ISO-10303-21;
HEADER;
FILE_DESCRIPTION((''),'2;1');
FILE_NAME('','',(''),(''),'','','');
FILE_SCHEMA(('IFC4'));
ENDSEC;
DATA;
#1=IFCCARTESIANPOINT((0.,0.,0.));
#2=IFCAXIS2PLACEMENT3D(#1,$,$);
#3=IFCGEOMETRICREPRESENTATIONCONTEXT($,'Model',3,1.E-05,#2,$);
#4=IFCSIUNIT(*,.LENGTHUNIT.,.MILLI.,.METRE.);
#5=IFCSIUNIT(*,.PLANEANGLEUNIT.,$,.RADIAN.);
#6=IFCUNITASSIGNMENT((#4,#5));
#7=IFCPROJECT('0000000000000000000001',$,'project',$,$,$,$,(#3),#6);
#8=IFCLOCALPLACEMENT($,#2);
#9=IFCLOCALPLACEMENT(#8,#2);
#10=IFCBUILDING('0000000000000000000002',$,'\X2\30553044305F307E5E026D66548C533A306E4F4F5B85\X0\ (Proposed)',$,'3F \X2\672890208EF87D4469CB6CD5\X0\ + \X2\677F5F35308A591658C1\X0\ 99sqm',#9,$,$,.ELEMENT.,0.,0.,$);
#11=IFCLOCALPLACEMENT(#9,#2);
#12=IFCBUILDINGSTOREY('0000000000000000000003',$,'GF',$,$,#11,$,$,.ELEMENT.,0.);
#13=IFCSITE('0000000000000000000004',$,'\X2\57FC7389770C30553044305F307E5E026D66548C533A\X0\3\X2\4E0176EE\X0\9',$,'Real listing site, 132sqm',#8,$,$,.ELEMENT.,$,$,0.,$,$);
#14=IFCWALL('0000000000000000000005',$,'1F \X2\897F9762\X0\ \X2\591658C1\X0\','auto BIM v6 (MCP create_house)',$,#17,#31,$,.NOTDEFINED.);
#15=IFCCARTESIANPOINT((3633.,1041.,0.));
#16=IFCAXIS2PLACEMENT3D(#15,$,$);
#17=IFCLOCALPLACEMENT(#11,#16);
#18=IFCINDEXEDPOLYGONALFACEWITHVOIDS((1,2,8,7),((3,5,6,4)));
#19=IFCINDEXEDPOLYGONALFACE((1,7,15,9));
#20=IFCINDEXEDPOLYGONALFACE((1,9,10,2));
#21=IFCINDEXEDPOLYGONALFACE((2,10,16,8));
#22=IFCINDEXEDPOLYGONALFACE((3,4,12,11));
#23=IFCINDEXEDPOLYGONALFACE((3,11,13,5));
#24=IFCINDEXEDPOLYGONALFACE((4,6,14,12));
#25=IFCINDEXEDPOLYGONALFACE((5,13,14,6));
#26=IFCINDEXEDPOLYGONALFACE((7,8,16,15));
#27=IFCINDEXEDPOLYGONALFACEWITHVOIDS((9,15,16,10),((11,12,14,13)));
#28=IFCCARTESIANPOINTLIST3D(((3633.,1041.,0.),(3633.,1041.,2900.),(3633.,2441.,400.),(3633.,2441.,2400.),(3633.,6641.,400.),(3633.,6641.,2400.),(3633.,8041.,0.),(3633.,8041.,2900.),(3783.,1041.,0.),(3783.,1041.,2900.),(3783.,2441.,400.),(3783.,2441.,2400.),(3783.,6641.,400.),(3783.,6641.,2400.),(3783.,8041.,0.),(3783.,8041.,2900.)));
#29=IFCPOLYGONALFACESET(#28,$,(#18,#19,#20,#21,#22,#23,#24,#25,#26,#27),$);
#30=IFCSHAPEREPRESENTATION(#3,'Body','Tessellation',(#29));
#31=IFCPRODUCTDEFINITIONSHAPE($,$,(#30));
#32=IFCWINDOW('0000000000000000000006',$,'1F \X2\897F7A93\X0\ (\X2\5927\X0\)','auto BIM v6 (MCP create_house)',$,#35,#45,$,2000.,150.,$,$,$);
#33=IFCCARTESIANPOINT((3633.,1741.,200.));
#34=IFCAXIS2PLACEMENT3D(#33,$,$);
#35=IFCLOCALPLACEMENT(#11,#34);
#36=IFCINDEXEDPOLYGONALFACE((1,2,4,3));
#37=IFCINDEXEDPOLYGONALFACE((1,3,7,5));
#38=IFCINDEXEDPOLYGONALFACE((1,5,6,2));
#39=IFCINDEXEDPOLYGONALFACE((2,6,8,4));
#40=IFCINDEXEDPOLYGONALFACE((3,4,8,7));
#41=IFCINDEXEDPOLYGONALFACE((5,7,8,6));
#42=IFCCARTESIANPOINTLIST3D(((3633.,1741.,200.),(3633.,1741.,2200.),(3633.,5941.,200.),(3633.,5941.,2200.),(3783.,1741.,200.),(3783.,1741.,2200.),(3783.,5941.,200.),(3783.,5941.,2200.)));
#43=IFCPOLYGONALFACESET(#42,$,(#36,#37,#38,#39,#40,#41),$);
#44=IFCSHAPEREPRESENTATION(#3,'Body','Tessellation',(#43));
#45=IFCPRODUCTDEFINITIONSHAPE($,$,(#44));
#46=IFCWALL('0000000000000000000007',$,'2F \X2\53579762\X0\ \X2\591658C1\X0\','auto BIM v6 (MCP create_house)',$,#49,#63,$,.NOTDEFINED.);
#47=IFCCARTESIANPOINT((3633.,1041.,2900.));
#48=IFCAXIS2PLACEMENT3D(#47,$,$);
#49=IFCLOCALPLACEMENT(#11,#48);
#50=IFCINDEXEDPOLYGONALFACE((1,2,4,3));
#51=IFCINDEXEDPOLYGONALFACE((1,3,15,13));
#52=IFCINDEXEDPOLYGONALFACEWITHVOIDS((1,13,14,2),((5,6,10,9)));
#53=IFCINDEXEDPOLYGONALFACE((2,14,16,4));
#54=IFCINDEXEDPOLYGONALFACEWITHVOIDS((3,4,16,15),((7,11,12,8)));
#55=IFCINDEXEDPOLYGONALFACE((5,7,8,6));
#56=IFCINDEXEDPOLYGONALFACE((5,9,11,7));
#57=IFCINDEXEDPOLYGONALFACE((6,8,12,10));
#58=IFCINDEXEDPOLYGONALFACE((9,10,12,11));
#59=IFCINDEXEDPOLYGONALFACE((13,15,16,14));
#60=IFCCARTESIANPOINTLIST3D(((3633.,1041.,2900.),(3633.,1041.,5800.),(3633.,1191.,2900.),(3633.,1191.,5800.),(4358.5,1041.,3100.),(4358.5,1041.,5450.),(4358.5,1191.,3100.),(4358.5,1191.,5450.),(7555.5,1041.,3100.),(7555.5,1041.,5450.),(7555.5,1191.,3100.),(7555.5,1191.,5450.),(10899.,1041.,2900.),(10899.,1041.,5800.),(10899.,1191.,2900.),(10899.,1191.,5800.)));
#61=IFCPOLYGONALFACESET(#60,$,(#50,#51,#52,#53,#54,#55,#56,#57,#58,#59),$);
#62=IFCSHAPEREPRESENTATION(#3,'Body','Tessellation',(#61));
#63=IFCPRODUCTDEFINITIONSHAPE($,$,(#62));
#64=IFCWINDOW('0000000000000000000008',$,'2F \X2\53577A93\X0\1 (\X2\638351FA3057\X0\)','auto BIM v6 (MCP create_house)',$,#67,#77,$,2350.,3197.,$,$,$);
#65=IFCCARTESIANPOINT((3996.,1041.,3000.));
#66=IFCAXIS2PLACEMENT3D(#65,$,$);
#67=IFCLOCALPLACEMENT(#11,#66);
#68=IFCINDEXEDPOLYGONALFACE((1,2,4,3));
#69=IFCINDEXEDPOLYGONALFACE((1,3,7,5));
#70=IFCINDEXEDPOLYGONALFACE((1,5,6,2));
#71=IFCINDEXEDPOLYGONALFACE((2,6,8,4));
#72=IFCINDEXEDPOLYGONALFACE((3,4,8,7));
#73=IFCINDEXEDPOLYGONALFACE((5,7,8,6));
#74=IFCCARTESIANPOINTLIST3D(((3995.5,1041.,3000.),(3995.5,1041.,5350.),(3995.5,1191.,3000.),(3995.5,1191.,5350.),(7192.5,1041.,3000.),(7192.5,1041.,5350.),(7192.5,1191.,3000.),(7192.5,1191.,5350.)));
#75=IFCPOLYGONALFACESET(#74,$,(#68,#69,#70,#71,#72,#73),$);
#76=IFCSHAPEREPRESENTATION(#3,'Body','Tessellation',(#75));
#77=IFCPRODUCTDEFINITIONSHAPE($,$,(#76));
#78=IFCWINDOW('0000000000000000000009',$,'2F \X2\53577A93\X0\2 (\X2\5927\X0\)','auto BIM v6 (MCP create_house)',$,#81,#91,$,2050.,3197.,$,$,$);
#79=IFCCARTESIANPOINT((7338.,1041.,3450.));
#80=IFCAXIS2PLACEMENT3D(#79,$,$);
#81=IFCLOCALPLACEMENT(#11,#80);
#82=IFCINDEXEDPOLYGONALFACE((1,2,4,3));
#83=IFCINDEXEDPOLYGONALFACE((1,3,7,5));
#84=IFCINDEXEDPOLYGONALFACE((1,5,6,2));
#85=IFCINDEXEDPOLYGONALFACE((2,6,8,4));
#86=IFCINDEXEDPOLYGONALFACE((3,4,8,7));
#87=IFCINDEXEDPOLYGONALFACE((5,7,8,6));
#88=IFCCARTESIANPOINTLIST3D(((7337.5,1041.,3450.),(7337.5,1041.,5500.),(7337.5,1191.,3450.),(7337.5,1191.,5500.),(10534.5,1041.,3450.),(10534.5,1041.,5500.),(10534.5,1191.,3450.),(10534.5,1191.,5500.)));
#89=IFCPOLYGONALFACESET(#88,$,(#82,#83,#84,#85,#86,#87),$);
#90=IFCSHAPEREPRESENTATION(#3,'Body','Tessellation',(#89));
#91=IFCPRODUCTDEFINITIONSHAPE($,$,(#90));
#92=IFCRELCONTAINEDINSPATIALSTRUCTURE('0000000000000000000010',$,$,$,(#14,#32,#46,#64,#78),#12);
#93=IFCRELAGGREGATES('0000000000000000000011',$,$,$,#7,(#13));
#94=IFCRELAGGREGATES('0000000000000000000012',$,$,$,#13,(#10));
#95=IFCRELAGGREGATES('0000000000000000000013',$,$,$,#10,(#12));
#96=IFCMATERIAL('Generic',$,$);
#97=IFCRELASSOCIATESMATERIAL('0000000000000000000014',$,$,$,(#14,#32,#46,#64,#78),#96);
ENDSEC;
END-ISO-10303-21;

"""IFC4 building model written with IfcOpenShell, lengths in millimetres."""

from ifc_helpers import new_model, si_unit, frame, frame_2d, origin, place, context, project, spatial, rectangle, extrude, material, element, fill, save


model = new_model("IFC4")

# Units and contexts
model_context = context("Model", 3, precision=1e-05, world=origin())
ifc_project = project(units=[si_unit("LENGTHUNIT", "METRE", prefix="MILLI"), si_unit("PLANEANGLEUNIT", "RADIAN")], contexts=[model_context])

# Site, building, storey
site_placement = place(None, origin())
site = spatial("IfcSite", under=ifc_project, at=site_placement, Name="埼玉県さいたま市浦和区3丁目9", ObjectType="Real listing site, 132sqm", CompositionType="ELEMENT", RefElevation=0.0)
building_placement = place(site_placement, origin())
building = spatial("IfcBuilding", under=site, at=building_placement, Name="さいたま市浦和区の住宅 (Proposed)", ObjectType="3F 木造軸組構法 + 板張り外壁 99sqm", CompositionType="ELEMENT", ElevationOfRefHeight=0.0, ElevationOfTerrain=0.0)
storey_placement = place(building_placement, origin())
storey = spatial("IfcBuildingStorey", under=building, at=storey_placement, Name="GF", CompositionType="ELEMENT", Elevation=0.0)

# Shared definitions
ifc_material = material(Name="Generic")

# Wall, opening, window
wall_1_placement = place(storey_placement, frame((3633.0, 1041.0, 0.0)))
wall_1 = element("IfcWall", 1, at=wall_1_placement, inside=storey, material=ifc_material, Name="1F 西面 外壁", Description="auto BIM v6 (MCP create_house)", PredefinedType="NOTDEFINED", context=model_context, shape_type="SweptSolid", body=[
    extrude(rectangle(XDim=150.0, YDim=7000.0, at=frame_2d((75.0, 3500.0))), frame((3633.0, 1041.0, 0.0)), (0.0, 0.0, 1.0), 2900.0),
])
opening_1_placement = place(storey_placement, frame((3633.0, 1741.0, 200.0)))
opening_1 = element("IfcOpeningElement", 2, at=opening_1_placement, cuts=wall_1, PredefinedType="NOTDEFINED", context=model_context, shape_type="SweptSolid", body=[
    extrude(rectangle(XDim=150.0, YDim=4200.0, at=frame_2d((75.0, 2100.0))), frame((3633.0, 1741.0, 200.0)), (0.0, 0.0, 1.0), 2000.0),
])
window_1_placement = place(storey_placement, frame((3633.0, 1741.0, 200.0)))
window_1 = element("IfcWindow", 3, at=window_1_placement, inside=storey, material=ifc_material, Name="1F 西窓 (大)", Description="auto BIM v6 (MCP create_house)", OverallHeight=2000.0, OverallWidth=150.0, context=model_context, shape_type="SweptSolid", body=[
    extrude(rectangle(XDim=150.0, YDim=4200.0, at=frame_2d((75.0, 2100.0))), frame((3633.0, 1741.0, 200.0)), (0.0, 0.0, 1.0), 2000.0),
])
fill(opening_1, window_1)

# Wall, openings, windows
wall_2_placement = place(storey_placement, frame((3633.0, 1041.0, 2900.0)))
wall_2 = element("IfcWall", 4, at=wall_2_placement, inside=storey, material=ifc_material, Name="2F 南面 外壁", Description="auto BIM v6 (MCP create_house)", PredefinedType="NOTDEFINED", context=model_context, shape_type="SweptSolid", body=[
    extrude(rectangle(XDim=7266.0, YDim=150.0, at=frame_2d((3633.0, 75.0))), frame((3633.0, 1041.0, 2900.0)), (0.0, 0.0, 1.0), 2900.0),
])
opening_2_placement = place(storey_placement, frame((3996.0, 1041.0, 3000.0)))
opening_2 = element("IfcOpeningElement", 5, at=opening_2_placement, cuts=wall_2, PredefinedType="NOTDEFINED", context=model_context, shape_type="SweptSolid", body=[
    extrude(rectangle(XDim=3197.0, YDim=150.0, at=frame_2d((1598.0, 75.0))), frame((3996.0, 1041.0, 3000.0)), (0.0, 0.0, 1.0), 2350.0),
])
opening_3_placement = place(storey_placement, frame((7338.0, 1041.0, 3450.0)))
opening_3 = element("IfcOpeningElement", 6, at=opening_3_placement, cuts=wall_2, PredefinedType="NOTDEFINED", context=model_context, shape_type="SweptSolid", body=[
    extrude(rectangle(XDim=3197.0, YDim=150.0, at=frame_2d((1598.0, 75.0))), frame((7338.0, 1041.0, 3450.0)), (0.0, 0.0, 1.0), 2050.0),
])
window_2_placement = place(storey_placement, frame((3996.0, 1041.0, 3000.0)))
window_2 = element("IfcWindow", 7, at=window_2_placement, inside=storey, material=ifc_material, Name="2F 南窓1 (掃出し)", Description="auto BIM v6 (MCP create_house)", OverallHeight=2350.0, OverallWidth=3197.0, context=model_context, shape_type="SweptSolid", body=[
    extrude(rectangle(XDim=3197.0, YDim=150.0, at=frame_2d((1598.0, 75.0))), frame((3996.0, 1041.0, 3000.0)), (0.0, 0.0, 1.0), 2350.0),
])
fill(opening_2, window_2)
window_3_placement = place(storey_placement, frame((7338.0, 1041.0, 3450.0)))
window_3 = element("IfcWindow", 8, at=window_3_placement, inside=storey, material=ifc_material, Name="2F 南窓2 (大)", Description="auto BIM v6 (MCP create_house)", OverallHeight=2050.0, OverallWidth=3197.0, context=model_context, shape_type="SweptSolid", body=[
    extrude(rectangle(XDim=3197.0, YDim=150.0, at=frame_2d((1598.0, 75.0))), frame((7338.0, 1041.0, 3450.0)), (0.0, 0.0, 1.0), 2050.0),
])
fill(opening_3, window_3)

save(model, "model.ifc")
